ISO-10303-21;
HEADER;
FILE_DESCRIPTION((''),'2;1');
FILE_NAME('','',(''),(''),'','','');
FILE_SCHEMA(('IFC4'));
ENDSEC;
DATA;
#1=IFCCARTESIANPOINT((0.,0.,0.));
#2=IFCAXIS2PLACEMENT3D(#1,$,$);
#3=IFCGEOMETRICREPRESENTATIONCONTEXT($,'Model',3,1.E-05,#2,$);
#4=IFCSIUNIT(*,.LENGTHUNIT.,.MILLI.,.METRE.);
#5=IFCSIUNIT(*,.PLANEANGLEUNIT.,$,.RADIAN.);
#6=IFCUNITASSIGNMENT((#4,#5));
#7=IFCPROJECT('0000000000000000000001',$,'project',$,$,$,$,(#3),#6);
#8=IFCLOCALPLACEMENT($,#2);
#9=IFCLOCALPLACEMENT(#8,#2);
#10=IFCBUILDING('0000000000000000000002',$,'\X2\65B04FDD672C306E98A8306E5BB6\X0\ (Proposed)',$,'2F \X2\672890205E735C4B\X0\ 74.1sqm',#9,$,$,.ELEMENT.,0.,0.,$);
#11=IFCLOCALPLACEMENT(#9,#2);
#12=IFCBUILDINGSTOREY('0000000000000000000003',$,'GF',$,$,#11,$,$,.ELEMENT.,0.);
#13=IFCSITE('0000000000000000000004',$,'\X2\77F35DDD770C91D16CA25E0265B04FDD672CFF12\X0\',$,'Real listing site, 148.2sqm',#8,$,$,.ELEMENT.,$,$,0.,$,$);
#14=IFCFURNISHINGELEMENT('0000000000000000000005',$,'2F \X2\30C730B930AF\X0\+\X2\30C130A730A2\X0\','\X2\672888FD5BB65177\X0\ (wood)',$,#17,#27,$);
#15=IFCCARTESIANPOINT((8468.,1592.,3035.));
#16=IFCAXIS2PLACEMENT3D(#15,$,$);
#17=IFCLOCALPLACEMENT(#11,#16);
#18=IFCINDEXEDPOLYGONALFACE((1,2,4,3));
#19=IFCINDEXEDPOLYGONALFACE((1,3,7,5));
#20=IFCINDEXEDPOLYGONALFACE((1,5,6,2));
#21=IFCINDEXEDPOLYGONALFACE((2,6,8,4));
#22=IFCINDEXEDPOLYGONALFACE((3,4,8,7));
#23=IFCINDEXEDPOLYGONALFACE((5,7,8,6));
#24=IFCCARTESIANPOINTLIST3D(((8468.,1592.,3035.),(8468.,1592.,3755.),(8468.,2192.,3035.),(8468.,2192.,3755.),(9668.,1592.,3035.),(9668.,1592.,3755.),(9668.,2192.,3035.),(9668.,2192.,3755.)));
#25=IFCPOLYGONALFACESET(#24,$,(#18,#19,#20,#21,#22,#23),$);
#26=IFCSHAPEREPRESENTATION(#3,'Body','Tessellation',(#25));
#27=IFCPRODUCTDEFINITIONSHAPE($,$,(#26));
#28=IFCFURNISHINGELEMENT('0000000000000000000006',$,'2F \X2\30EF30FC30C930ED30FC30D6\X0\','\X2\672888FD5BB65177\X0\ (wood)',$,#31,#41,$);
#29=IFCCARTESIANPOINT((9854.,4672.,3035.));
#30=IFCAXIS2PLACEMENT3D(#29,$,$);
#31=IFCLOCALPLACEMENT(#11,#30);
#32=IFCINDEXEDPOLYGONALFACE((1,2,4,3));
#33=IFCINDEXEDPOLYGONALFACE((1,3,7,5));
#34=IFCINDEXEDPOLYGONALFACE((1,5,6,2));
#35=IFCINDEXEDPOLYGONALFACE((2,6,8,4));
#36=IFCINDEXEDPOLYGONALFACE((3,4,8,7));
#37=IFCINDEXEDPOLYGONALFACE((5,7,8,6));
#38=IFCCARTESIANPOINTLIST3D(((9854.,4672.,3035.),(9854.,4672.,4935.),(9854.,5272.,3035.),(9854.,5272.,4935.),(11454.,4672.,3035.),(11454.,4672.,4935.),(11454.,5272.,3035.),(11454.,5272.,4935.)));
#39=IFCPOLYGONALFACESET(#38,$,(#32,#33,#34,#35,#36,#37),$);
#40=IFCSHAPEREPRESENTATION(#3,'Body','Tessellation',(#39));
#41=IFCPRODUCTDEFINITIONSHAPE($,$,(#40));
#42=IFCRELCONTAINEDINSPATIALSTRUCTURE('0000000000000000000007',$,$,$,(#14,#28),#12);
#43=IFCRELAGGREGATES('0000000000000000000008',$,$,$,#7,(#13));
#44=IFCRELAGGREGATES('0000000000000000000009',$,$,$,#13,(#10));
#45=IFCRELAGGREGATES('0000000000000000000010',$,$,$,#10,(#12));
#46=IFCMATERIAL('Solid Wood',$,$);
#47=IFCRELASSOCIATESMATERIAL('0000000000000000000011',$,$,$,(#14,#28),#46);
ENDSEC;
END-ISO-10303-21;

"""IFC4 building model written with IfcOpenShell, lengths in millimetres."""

from ifc_helpers import new_model, si_unit, frame, frame_2d, origin, place, context, project, spatial, rectangle, extrude, material, element, save


model = new_model("IFC4")

# Units and contexts
model_context = context("Model", 3, precision=1e-05, world=origin())
ifc_project = project(units=[si_unit("LENGTHUNIT", "METRE", prefix="MILLI"), si_unit("PLANEANGLEUNIT", "RADIAN")], contexts=[model_context])

# Site, building, storey
site_placement = place(None, origin())
site = spatial("IfcSite", under=ifc_project, at=site_placement, Name="石川県金沢市新保本２", ObjectType="Real listing site, 148.2sqm", CompositionType="ELEMENT", RefElevation=0.0)
building_placement = place(site_placement, origin())
building = spatial("IfcBuilding", under=site, at=building_placement, Name="新保本の風の家 (Proposed)", ObjectType="2F 木造平屋 74.1sqm", CompositionType="ELEMENT", ElevationOfRefHeight=0.0, ElevationOfTerrain=0.0)
storey_placement = place(building_placement, origin())
storey = spatial("IfcBuildingStorey", under=building, at=storey_placement, Name="GF", CompositionType="ELEMENT", Elevation=0.0)

# Shared definitions
ifc_material_1 = material(Name="Solid Wood")

# Furnishing elements
furnishing_1_placement = place(storey_placement, frame((8468.0, 1592.0, 3035.0)))
element("IfcFurnishingElement", 1, at=furnishing_1_placement, inside=storey, material=ifc_material_1, Name="2F デスク+チェア", Description="木製家具 (wood)", context=model_context, shape_type="SweptSolid", body=[
    extrude(rectangle(XDim=1200.0, YDim=600.0, at=frame_2d((600.0, 300.0))), frame((8468.0, 1592.0, 3035.0)), (0.0, 0.0, 1.0), 720.0),
])
furnishing_2_placement = place(storey_placement, frame((9854.0, 4672.0, 3035.0)))
element("IfcFurnishingElement", 2, at=furnishing_2_placement, inside=storey, material=ifc_material_1, Name="2F ワードローブ", Description="木製家具 (wood)", context=model_context, shape_type="SweptSolid", body=[
    extrude(rectangle(XDim=1600.0, YDim=600.0, at=frame_2d((800.0, 300.0))), frame((9854.0, 4672.0, 3035.0)), (0.0, 0.0, 1.0), 1900.0),
])

save(model, "model.ifc")
